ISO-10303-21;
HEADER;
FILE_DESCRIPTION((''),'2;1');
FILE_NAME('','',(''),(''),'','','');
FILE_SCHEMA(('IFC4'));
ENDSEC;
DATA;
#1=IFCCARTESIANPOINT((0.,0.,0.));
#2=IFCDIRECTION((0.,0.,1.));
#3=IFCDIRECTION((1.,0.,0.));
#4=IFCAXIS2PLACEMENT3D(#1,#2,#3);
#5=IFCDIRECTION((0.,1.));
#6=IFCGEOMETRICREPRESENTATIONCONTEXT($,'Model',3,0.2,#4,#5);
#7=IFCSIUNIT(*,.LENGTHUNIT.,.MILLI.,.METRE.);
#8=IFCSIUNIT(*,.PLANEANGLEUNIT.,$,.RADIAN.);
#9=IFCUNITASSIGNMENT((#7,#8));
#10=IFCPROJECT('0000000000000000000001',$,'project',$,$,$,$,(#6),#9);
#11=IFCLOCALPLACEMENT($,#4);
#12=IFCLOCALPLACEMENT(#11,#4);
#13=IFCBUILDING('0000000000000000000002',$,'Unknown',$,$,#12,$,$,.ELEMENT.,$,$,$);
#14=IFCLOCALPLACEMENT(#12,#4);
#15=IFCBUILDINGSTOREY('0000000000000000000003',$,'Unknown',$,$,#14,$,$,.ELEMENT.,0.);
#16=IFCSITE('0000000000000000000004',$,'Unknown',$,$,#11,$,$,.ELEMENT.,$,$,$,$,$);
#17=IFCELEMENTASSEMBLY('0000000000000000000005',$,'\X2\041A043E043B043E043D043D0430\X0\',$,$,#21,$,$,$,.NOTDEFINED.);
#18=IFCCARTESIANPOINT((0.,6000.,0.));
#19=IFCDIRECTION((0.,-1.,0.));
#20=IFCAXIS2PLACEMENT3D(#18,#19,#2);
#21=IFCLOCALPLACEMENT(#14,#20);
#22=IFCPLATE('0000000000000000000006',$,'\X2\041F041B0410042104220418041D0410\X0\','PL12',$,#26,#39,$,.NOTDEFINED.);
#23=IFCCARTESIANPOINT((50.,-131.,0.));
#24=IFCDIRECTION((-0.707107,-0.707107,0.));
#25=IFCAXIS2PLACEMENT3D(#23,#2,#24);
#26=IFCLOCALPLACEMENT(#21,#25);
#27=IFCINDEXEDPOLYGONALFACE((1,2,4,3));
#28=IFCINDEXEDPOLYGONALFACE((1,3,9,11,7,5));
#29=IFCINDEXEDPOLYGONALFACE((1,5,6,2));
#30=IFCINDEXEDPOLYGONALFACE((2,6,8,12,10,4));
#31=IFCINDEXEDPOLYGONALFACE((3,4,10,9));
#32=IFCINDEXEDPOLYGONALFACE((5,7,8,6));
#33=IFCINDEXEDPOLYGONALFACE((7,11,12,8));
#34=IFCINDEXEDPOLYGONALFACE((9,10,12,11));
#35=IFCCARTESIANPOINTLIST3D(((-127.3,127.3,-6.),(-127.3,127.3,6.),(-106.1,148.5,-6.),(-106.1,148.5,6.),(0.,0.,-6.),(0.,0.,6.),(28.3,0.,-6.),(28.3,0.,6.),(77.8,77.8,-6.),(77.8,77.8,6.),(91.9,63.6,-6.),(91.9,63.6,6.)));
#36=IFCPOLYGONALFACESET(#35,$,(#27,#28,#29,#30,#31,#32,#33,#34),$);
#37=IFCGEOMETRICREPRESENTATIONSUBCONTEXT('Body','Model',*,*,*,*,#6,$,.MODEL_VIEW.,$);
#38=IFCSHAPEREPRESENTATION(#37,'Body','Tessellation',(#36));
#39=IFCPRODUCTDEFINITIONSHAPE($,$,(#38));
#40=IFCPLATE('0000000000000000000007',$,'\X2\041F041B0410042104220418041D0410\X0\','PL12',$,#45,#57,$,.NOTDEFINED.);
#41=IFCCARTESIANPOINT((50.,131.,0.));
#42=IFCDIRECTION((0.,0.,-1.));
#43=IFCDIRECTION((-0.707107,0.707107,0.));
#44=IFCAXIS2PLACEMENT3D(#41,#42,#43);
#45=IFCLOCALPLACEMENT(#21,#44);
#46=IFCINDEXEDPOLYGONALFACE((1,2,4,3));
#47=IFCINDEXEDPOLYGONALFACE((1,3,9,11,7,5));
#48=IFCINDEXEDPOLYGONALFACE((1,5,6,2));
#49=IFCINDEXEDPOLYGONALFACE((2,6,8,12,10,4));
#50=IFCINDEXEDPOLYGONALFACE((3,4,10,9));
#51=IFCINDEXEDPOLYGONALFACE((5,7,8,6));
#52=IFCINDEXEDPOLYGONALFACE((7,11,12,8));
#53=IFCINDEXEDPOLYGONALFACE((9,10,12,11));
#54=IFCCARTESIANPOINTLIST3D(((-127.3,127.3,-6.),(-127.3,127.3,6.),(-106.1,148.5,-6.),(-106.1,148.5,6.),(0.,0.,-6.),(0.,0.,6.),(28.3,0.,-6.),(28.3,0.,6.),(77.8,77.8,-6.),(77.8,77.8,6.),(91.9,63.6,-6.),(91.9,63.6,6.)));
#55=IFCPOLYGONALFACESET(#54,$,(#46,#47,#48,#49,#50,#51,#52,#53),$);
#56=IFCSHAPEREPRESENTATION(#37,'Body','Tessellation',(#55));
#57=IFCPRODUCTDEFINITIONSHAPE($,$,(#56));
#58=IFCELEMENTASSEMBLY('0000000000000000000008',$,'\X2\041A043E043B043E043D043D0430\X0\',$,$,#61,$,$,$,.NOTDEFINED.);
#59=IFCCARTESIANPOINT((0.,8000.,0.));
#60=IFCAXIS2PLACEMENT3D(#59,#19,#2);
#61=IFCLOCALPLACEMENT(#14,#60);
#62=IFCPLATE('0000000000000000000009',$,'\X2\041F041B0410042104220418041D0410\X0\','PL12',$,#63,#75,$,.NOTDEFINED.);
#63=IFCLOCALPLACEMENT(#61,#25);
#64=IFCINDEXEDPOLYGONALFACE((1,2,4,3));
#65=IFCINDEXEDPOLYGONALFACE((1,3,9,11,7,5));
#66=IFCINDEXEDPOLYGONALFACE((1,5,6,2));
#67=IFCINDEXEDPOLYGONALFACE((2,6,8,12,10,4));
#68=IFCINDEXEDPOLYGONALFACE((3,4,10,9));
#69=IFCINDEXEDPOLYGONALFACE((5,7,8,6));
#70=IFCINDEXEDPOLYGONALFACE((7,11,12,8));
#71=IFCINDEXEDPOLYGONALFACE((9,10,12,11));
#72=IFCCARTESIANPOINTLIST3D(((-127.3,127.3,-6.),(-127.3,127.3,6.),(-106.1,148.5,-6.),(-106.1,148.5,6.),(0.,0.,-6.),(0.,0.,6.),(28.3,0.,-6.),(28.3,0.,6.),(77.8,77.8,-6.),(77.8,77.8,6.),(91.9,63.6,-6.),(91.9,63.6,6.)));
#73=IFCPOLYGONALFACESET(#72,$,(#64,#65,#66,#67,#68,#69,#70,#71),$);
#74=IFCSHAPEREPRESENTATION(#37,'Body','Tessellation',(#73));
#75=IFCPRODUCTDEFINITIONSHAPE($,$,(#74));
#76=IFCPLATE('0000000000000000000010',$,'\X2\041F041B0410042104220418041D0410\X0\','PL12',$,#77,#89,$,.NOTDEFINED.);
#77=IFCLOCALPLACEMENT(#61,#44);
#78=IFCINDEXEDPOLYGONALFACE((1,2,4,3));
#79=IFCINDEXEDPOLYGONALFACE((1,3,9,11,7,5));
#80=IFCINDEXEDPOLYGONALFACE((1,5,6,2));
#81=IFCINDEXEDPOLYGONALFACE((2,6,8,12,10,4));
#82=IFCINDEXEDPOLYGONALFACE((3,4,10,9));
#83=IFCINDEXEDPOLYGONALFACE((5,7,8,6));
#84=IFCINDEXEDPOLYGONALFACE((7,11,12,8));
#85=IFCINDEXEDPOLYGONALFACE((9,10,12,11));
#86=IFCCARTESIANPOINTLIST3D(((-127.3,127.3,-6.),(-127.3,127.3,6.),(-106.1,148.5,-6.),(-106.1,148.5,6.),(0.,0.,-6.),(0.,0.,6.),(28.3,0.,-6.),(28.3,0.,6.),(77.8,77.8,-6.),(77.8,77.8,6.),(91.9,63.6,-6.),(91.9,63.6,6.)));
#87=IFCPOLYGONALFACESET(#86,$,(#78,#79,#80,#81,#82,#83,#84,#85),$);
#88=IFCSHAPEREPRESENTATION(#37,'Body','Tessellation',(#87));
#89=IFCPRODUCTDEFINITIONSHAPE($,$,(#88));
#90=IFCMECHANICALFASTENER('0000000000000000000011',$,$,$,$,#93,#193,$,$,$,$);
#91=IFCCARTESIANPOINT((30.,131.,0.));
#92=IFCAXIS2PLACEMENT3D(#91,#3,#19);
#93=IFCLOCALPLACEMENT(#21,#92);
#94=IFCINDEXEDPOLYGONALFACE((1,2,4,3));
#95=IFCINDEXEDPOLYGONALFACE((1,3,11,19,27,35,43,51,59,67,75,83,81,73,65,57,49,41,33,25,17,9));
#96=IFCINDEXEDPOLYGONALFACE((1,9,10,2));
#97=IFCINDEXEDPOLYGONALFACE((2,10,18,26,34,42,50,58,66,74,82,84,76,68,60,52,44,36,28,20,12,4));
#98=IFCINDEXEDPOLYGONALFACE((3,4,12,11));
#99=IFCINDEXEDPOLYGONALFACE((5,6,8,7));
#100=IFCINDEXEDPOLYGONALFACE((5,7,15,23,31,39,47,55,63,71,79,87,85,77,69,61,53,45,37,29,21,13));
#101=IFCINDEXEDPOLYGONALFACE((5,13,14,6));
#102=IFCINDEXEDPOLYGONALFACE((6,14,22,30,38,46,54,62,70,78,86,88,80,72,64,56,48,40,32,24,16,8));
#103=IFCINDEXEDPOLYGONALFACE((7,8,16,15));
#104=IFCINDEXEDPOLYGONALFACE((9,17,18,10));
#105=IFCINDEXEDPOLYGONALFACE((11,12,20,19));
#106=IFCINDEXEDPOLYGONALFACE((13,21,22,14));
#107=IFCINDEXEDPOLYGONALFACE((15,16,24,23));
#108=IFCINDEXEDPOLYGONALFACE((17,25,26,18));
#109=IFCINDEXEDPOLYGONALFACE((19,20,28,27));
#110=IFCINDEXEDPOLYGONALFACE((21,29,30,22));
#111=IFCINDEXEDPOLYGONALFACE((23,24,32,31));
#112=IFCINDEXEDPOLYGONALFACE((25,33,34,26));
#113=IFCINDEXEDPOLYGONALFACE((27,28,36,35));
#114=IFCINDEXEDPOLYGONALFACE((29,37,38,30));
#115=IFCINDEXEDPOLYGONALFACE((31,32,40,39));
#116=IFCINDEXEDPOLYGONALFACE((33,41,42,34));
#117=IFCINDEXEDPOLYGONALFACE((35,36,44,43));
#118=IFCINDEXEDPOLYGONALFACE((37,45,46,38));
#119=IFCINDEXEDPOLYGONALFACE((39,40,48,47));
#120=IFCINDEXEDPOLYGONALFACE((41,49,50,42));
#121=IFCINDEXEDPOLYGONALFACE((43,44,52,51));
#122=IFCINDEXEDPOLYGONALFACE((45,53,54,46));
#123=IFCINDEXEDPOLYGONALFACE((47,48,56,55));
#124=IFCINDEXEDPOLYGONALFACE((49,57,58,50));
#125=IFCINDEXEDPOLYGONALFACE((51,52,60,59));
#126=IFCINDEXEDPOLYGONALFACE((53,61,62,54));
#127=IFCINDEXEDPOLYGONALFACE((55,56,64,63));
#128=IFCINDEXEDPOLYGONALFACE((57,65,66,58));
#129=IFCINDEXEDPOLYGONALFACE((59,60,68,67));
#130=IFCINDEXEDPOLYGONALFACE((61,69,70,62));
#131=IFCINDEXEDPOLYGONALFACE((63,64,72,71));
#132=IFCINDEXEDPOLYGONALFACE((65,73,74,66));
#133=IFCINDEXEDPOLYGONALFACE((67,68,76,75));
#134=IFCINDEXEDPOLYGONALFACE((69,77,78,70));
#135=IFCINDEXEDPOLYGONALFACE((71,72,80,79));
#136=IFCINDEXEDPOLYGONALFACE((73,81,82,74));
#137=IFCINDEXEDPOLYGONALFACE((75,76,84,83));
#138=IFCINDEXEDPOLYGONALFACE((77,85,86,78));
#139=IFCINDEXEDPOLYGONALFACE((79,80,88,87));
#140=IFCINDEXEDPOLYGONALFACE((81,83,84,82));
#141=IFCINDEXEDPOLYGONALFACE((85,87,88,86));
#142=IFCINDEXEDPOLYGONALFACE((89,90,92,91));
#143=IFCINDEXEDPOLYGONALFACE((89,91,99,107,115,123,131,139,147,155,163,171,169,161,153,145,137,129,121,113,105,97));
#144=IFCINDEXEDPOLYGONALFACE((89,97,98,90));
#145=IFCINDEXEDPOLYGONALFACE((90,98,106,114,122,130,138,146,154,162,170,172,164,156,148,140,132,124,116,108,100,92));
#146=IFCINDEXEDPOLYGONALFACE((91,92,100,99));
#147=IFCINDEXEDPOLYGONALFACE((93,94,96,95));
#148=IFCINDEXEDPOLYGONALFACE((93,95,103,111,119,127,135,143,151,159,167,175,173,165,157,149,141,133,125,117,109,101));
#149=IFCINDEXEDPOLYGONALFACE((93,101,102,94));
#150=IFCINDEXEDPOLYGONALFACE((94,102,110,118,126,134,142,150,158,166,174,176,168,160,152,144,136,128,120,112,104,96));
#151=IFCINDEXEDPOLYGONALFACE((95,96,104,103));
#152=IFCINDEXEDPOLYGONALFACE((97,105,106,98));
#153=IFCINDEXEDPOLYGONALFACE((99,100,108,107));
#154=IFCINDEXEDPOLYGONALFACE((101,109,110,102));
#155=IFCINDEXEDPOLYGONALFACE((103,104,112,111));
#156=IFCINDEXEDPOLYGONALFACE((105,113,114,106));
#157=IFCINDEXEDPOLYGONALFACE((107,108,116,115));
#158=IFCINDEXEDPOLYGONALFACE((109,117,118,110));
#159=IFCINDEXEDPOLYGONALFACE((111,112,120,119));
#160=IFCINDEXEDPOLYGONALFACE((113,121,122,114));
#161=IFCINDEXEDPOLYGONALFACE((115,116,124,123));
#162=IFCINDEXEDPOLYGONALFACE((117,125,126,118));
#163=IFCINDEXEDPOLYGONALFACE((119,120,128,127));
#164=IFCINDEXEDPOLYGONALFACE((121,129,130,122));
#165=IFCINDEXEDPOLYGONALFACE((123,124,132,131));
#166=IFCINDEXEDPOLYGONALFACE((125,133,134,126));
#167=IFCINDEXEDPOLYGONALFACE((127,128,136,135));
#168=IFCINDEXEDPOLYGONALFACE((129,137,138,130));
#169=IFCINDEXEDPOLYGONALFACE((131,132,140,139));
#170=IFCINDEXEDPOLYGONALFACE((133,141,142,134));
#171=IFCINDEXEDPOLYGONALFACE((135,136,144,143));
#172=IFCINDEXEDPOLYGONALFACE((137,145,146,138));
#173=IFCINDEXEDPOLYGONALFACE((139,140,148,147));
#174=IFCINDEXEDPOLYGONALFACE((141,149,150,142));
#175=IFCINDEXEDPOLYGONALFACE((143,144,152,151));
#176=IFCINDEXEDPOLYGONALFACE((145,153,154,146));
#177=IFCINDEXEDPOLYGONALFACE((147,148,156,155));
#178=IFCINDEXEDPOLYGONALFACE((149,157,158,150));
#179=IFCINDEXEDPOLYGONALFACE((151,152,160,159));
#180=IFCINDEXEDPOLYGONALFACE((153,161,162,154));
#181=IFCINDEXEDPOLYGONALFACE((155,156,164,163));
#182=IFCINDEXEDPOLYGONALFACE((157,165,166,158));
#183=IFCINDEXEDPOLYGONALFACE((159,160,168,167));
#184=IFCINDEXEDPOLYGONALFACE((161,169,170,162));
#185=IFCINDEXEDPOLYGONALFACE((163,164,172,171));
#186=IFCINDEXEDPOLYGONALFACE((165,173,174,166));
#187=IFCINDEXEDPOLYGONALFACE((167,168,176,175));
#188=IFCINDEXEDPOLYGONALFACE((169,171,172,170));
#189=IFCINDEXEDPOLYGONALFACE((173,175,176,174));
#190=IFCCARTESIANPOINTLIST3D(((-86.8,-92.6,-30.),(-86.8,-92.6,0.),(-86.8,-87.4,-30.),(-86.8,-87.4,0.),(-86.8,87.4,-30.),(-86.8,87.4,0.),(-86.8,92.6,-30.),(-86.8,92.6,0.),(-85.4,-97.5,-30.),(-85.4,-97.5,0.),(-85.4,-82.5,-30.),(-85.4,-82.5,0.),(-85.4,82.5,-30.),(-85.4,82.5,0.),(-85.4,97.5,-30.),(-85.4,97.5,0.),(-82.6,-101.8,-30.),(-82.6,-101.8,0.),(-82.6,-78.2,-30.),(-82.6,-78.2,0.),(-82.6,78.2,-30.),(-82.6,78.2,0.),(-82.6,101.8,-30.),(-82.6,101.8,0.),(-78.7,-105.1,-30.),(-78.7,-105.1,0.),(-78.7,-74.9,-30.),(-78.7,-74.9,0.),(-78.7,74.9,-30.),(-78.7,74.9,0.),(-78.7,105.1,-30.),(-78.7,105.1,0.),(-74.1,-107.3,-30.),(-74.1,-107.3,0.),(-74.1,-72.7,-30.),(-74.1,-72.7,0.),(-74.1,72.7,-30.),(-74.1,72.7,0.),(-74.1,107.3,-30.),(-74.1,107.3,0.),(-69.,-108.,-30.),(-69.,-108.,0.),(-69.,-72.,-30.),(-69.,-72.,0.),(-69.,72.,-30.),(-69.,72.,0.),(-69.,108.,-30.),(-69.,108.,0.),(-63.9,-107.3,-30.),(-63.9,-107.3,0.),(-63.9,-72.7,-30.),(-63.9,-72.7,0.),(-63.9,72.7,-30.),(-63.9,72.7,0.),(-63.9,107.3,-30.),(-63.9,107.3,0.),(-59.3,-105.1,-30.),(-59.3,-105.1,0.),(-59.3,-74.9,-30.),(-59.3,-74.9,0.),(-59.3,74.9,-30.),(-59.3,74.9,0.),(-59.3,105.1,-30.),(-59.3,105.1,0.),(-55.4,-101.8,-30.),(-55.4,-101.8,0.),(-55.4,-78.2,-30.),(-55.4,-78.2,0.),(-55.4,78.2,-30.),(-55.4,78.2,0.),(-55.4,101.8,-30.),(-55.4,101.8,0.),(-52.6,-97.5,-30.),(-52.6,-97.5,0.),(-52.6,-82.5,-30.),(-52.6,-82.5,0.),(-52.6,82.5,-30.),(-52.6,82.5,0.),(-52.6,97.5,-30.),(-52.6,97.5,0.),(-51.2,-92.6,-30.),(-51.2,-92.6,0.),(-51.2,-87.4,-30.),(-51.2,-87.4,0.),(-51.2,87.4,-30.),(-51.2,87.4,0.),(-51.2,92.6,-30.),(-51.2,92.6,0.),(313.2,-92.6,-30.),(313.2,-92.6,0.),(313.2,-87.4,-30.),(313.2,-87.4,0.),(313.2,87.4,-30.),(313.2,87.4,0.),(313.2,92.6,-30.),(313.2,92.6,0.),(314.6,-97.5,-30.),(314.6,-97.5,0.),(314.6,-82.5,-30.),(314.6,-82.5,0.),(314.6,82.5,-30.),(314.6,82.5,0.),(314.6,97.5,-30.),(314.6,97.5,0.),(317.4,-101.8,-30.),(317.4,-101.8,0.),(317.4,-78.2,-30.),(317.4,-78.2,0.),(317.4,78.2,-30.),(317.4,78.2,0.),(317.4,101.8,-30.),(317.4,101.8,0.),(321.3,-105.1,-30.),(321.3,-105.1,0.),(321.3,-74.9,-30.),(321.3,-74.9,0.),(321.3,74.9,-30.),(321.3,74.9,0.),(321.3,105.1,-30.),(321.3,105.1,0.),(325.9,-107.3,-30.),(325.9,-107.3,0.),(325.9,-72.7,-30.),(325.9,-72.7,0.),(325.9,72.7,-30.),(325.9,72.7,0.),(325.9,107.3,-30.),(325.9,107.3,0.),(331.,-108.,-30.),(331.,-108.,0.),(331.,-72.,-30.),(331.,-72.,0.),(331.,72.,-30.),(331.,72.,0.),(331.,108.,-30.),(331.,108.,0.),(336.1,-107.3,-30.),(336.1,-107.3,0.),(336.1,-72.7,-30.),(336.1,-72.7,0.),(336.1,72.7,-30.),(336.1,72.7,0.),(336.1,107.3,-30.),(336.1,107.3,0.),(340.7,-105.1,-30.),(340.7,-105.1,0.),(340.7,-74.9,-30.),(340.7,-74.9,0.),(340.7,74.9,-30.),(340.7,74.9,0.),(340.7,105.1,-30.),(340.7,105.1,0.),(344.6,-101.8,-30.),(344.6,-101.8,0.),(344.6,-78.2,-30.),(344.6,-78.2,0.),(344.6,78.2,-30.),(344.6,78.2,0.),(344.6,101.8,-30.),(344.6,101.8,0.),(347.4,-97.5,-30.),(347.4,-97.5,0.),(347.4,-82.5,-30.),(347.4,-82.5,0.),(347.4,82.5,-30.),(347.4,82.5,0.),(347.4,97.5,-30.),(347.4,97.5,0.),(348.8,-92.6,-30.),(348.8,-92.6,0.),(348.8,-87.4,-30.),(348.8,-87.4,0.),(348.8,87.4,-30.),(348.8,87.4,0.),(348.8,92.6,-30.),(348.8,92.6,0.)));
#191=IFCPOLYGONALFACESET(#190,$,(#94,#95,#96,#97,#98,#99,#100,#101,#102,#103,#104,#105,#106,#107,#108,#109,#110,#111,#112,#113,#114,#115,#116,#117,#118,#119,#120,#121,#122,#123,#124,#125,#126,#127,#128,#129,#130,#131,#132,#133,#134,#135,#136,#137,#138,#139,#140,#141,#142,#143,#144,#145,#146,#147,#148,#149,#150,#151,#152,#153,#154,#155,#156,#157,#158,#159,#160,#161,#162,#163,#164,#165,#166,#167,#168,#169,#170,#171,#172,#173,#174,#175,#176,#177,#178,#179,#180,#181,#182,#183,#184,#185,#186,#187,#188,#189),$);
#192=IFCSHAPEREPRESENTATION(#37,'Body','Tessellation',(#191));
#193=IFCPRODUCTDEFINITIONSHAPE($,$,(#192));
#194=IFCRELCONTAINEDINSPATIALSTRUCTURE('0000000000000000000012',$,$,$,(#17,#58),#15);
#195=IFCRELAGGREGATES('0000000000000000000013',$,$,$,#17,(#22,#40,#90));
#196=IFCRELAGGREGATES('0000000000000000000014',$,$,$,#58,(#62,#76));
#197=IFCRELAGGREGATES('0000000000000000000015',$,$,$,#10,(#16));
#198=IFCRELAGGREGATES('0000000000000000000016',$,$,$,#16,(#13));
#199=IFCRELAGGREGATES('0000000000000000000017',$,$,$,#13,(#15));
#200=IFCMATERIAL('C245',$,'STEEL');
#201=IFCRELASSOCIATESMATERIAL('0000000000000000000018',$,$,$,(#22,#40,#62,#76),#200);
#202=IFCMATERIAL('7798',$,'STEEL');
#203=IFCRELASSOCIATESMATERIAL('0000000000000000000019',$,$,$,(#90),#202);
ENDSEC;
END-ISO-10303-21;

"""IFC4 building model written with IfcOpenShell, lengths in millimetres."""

from ifc_helpers import new_model, si_unit, direction, frame, origin_with_axes, place, context, subcontext, project, spatial, line, arc, indexed_curve, outline, extrude, source, transform, mapped, material, element, aggregate, save


model = new_model("IFC4")

# Units and contexts
model_context = context("Model", 3, precision=0.2, world=origin_with_axes(), true_north=direction((0.0, 1.0)))
body_context = subcontext(model_context, "Body", "Model", "MODEL_VIEW")
ifc_project = project(units=[si_unit("LENGTHUNIT", "METRE", prefix="MILLI"), si_unit("PLANEANGLEUNIT", "RADIAN")], contexts=[model_context])

# Site, building, storey
site_placement = place(None, origin_with_axes())
site = spatial("IfcSite", under=ifc_project, at=site_placement, Name="Unknown", CompositionType="ELEMENT")
building_placement = place(site_placement, origin_with_axes())
building = spatial("IfcBuilding", under=site, at=building_placement, Name="Unknown", CompositionType="ELEMENT")
storey_placement = place(building_placement, origin_with_axes())
storey = spatial("IfcBuildingStorey", under=building, at=storey_placement, Name="Unknown", CompositionType="ELEMENT", Elevation=0.0)

# Element assemblies, plates
assembly_1_placement = place(storey_placement, frame((0.0, 6000.0, 0.0), z_axis=(0.0, -1.0, 0.0), x_axis=(0.0, 0.0, 1.0)))
assembly_1 = element("IfcElementAssembly", 1, at=assembly_1_placement, inside=storey, Name="Колонна", PredefinedType="NOTDEFINED")
ifc_material_1 = material(Name="C245", Category="STEEL")
plate_1_placement = place(assembly_1_placement, frame((50.0, -131.0, 0.0), z_axis=(0.0, 0.0, 1.0), x_axis=(-0.707107, -0.707107, 0.0)))
plate_1 = element("IfcPlate", 2, at=plate_1_placement, material=ifc_material_1, Name="ПЛАСТИНА", Description="PL12", PredefinedType="NOTDEFINED", context=body_context, shape_type="SolidModel", body=[
    extrude(outline(indexed_curve([(0.0, 0.0), (28.3, 0.0), (91.9, 63.6), (77.8, 77.8), (-106.1, 148.5), (-127.3, 127.3)], segments=[line(1, 2, 3, 4, 5, 6, 1)])), frame((0.0, 0.0, 6.0), z_axis=(0.0, 0.0, 1.0), x_axis=(1.0, 0.0, 0.0)), (0.0, 0.0, -1.0), 12.0),
])
plate_2_placement = place(assembly_1_placement, frame((50.0, 131.0, 0.0), z_axis=(0.0, 0.0, -1.0), x_axis=(-0.707107, 0.707107, 0.0)))
plate_2 = element("IfcPlate", 3, at=plate_2_placement, material=ifc_material_1, Name="ПЛАСТИНА", Description="PL12", PredefinedType="NOTDEFINED", context=body_context, shape_type="SolidModel", body=[
    extrude(outline(indexed_curve([(0.0, 0.0), (28.3, 0.0), (91.9, 63.6), (77.8, 77.8), (-106.1, 148.5), (-127.3, 127.3)], segments=[line(1, 2, 3, 4, 5, 6, 1)])), frame((0.0, 0.0, 6.0), z_axis=(0.0, 0.0, 1.0), x_axis=(1.0, 0.0, 0.0)), (0.0, 0.0, -1.0), 12.0),
])
assembly_2_placement = place(storey_placement, frame((0.0, 8000.0, 0.0), z_axis=(0.0, -1.0, 0.0), x_axis=(0.0, 0.0, 1.0)))
assembly_2 = element("IfcElementAssembly", 4, at=assembly_2_placement, inside=storey, Name="Колонна", PredefinedType="NOTDEFINED")
plate_3_placement = place(assembly_2_placement, frame((50.0, -131.0, 0.0), z_axis=(0.0, 0.0, 1.0), x_axis=(-0.707107, -0.707107, 0.0)))
plate_3 = element("IfcPlate", 5, at=plate_3_placement, material=ifc_material_1, Name="ПЛАСТИНА", Description="PL12", PredefinedType="NOTDEFINED", context=body_context, shape_type="SolidModel", body=[
    extrude(outline(indexed_curve([(0.0, 0.0), (28.3, 0.0), (91.9, 63.6), (77.8, 77.8), (-106.1, 148.5), (-127.3, 127.3)], segments=[line(1, 2, 3, 4, 5, 6, 1)])), frame((0.0, 0.0, 6.0), z_axis=(0.0, 0.0, 1.0), x_axis=(1.0, 0.0, 0.0)), (0.0, 0.0, -1.0), 12.0),
])
plate_4_placement = place(assembly_2_placement, frame((50.0, 131.0, 0.0), z_axis=(0.0, 0.0, -1.0), x_axis=(-0.707107, 0.707107, 0.0)))
plate_4 = element("IfcPlate", 6, at=plate_4_placement, material=ifc_material_1, Name="ПЛАСТИНА", Description="PL12", PredefinedType="NOTDEFINED", context=body_context, shape_type="SolidModel", body=[
    extrude(outline(indexed_curve([(0.0, 0.0), (28.3, 0.0), (91.9, 63.6), (77.8, 77.8), (-106.1, 148.5), (-127.3, 127.3)], segments=[line(1, 2, 3, 4, 5, 6, 1)])), frame((0.0, 0.0, 6.0), z_axis=(0.0, 0.0, 1.0), x_axis=(1.0, 0.0, 0.0)), (0.0, 0.0, -1.0), 12.0),
])

# Mechanical fastener
ifc_material_2 = material(Name="7798", Category="STEEL")
shared_shape_1 = source(origin_with_axes(), body_context, "Body", "SweptSolid", [
    extrude(outline(indexed_curve([(18.0, 0.0), (0.0, 18.0), (-18.0, 0.0), (0.0, -18.0)], segments=[arc(1, 2, 3), arc(3, 4, 1)])), frame((0.0, 0.0, 0.0), z_axis=(0.0, 0.0, -1.0), x_axis=(0.0, 1.0, 0.0)), (0.0, 0.0, 1.0), 30.0),
])
mechanical_fastener_1_placement = place(assembly_1_placement, frame((30.0, 131.0, 0.0), z_axis=(1.0, 0.0, 0.0), x_axis=(0.0, -1.0, 0.0)))
mechanical_fastener_1 = element("IfcMechanicalFastener", 7, at=mechanical_fastener_1_placement, material=ifc_material_2, context=body_context, shape_type="MappedRepresentation", body=[
    mapped(shared_shape_1, transform((-69.0, -90.0, 0.0))),
    mapped(shared_shape_1, transform((-69.0, 90.0, 0.0))),
    mapped(shared_shape_1, transform((331.0, -90.0, 0.0))),
    mapped(shared_shape_1, transform((331.0, 90.0, 0.0))),
])
aggregate(assembly_1, [plate_1, plate_2, mechanical_fastener_1])
aggregate(assembly_2, [plate_3, plate_4])

save(model, "model.ifc")
